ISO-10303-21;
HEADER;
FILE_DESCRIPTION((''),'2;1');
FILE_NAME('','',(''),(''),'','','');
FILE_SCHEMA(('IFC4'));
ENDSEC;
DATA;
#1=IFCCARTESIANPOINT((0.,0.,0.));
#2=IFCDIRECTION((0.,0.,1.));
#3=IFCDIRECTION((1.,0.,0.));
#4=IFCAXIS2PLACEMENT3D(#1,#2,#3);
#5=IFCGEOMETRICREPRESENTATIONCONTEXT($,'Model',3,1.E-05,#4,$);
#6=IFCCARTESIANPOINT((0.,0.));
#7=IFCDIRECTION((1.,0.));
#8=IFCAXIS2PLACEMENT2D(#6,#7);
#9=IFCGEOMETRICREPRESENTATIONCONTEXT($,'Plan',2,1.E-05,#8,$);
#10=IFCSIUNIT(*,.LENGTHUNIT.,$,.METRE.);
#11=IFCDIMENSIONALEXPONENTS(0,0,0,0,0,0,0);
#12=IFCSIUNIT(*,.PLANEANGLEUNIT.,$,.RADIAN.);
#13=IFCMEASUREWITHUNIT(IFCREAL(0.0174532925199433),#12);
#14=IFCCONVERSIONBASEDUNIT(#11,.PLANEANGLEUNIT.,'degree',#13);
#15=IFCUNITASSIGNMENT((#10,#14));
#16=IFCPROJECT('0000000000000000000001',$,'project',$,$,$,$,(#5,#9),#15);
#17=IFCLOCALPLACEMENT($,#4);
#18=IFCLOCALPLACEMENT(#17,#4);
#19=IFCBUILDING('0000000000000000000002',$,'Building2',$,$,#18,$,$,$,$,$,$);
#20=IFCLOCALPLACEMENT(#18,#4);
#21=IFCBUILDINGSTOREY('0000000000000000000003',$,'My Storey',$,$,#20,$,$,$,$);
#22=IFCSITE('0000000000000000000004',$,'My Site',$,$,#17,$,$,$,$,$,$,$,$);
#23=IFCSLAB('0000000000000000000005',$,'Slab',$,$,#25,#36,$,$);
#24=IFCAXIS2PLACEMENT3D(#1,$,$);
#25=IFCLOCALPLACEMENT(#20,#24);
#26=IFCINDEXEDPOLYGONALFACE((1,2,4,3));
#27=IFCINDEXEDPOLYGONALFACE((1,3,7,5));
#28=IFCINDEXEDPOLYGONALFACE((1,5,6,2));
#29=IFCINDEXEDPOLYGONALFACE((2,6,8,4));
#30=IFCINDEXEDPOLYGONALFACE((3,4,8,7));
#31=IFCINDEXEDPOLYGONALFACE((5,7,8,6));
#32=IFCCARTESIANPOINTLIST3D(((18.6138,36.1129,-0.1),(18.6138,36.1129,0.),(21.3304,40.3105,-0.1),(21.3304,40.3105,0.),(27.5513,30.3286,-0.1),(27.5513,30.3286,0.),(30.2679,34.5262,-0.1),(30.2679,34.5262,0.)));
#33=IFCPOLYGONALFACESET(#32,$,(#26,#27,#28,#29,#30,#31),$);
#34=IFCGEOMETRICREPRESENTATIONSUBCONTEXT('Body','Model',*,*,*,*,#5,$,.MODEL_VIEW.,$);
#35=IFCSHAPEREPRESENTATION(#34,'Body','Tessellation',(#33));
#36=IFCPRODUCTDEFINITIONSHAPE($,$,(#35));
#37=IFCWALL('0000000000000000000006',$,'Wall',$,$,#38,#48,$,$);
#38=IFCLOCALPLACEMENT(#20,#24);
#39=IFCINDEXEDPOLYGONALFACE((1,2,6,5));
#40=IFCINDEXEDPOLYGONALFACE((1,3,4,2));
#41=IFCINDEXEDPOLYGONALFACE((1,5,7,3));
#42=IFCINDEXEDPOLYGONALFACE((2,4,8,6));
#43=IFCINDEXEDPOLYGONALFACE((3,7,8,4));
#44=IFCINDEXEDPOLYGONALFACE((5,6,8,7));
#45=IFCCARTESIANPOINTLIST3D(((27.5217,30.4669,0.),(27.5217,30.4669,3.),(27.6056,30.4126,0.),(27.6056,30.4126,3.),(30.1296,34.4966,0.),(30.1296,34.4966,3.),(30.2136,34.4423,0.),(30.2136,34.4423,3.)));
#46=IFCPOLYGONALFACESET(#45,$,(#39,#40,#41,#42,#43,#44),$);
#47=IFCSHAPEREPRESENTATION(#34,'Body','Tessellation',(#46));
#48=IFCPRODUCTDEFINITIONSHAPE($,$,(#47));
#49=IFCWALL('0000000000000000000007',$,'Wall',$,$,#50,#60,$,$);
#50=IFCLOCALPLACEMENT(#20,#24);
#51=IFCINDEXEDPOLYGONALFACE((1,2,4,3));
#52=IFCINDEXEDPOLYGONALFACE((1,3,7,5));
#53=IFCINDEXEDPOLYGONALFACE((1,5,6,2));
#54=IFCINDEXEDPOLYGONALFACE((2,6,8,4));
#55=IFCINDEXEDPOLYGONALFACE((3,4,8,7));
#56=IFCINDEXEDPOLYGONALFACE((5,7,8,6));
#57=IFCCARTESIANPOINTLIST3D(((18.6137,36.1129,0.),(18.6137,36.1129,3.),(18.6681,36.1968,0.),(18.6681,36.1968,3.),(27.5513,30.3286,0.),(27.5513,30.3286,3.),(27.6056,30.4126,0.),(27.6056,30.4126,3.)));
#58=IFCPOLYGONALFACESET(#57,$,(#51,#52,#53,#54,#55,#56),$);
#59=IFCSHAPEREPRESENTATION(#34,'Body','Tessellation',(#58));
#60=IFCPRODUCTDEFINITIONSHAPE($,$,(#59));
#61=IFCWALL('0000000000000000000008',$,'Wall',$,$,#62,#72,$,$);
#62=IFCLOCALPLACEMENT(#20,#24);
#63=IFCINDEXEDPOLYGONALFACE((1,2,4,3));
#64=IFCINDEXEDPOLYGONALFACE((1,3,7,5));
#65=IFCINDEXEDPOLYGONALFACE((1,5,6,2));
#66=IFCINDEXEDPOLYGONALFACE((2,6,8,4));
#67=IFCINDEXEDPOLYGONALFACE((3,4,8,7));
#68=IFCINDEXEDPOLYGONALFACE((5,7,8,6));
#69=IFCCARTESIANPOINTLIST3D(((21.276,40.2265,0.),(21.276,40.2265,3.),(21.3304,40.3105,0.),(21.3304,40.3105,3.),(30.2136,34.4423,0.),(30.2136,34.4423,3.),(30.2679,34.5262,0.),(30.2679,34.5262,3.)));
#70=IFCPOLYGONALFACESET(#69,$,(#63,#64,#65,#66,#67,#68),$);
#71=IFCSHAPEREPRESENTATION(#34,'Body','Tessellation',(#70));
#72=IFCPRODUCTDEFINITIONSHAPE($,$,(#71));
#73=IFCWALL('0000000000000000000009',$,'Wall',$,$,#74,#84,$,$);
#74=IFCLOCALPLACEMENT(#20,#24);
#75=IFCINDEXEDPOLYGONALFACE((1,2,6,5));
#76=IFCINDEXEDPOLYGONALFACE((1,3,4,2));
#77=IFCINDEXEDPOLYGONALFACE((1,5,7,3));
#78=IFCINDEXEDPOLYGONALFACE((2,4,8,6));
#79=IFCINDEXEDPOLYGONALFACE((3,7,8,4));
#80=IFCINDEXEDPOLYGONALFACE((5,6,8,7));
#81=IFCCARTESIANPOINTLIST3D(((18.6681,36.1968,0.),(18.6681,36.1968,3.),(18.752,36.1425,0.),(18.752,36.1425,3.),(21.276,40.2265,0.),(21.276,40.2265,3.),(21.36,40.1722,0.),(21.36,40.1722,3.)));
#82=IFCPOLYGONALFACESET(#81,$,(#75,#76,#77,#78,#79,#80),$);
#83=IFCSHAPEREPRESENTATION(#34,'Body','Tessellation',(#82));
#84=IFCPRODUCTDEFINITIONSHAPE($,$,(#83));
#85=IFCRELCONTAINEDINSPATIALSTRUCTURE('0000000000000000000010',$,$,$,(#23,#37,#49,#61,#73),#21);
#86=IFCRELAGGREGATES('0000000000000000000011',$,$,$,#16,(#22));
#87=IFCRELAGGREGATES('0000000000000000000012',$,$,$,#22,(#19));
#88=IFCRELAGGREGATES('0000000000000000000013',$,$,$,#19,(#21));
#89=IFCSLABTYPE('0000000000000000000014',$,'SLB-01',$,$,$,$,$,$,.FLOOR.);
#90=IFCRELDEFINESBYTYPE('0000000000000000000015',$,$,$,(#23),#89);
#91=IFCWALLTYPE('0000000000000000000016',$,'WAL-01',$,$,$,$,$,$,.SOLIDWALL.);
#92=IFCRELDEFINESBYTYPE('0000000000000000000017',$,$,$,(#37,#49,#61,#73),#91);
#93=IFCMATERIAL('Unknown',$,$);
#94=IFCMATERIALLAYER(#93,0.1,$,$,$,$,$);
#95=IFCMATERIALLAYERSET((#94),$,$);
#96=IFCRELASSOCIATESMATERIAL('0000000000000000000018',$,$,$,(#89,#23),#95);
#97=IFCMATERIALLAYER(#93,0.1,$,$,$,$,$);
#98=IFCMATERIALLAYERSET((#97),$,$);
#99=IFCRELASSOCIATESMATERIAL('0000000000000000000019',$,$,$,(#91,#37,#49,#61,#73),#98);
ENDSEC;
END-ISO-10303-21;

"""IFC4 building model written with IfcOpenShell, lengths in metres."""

from ifc_helpers import new_model, entity, si_unit, converted_unit, frame, origin_with_axes, origin_2d_with_axis, place, context, subcontext, project, spatial, line, indexed_curve, outline, extrude, material, layer, layer_set, layer_usage, type_object, element, save


model = new_model("IFC4")

# Units and contexts
model_context = context("Model", 3, precision=1e-05, world=origin_with_axes())
plan_context = context("Plan", 2, precision=1e-05, world=origin_2d_with_axis())
body_context = subcontext(model_context, "Body", "Model", "MODEL_VIEW")
ifc_project = project(units=[si_unit("LENGTHUNIT", "METRE"), converted_unit("PLANEANGLEUNIT", "degree", entity("IfcReal", 0.0174532925199433), si_unit("PLANEANGLEUNIT", "RADIAN"), dimensions=[0, 0, 0, 0, 0, 0, 0])], contexts=[model_context, plan_context])

# Site, building, storey
site_placement = place(None, origin_with_axes())
site = spatial("IfcSite", under=ifc_project, at=site_placement, Name="My Site")
building_placement = place(site_placement, origin_with_axes())
building = spatial("IfcBuilding", under=site, at=building_placement, Name="Building2")
storey_placement = place(building_placement, origin_with_axes())
storey = spatial("IfcBuildingStorey", under=building, at=storey_placement, Name="My Storey")

# Slab
ifc_material = material(Name="Unknown")
ifc_layer_1 = layer(ifc_material, 0.1)
ifc_layer_set_1 = layer_set([ifc_layer_1])
ifc_layer_usage_1 = layer_usage(ifc_layer_set_1, "AXIS3", "POSITIVE", 0.0)
slab_type = type_object("IfcSlabType", Name="SLB-01", PredefinedType="FLOOR", material=ifc_layer_set_1)
slab_placement = place(storey_placement, frame((18.6138, 36.1129, -0.1), z_axis=(0.0, 0.0, 1.0), x_axis=(0.839523, -0.543324, 0.0)))
element("IfcSlab", 1, at=slab_placement, inside=storey, type_object=slab_type, material=ifc_layer_usage_1, Name="Slab", context=body_context, shape_type="SweptSolid", body=[
    extrude(outline(indexed_curve([(0.0, 0.0), (10.646, 0.0), (10.646, 5.0), (0.0, 5.0)], segments=[line(3, 2), line(2, 1), line(1, 4), line(4, 3)], self_intersect=False)), None, (0.0, 0.0, 1.0), 0.1),
])

# Walls
ifc_layer_2 = layer(ifc_material, 0.1)
ifc_layer_set_2 = layer_set([ifc_layer_2])
ifc_layer_usage_2 = layer_usage(ifc_layer_set_2, "AXIS2", "POSITIVE", 0.0)
wall_type = type_object("IfcWallType", Name="WAL-01", PredefinedType="SOLIDWALL", material=ifc_layer_set_2)
wall_1_placement = place(storey_placement, frame((27.6056, 30.4126, 0.0), z_axis=(0.0, 0.0, 1.0), x_axis=(0.543324, 0.839523, 0.0)))
element("IfcWall", 2, at=wall_1_placement, inside=storey, type_object=wall_type, material=ifc_layer_usage_2, Name="Wall", context=body_context, shape_type="SweptSolid", body=[
    extrude(outline(indexed_curve([(0.0, 0.0), (0.0, 0.1), (4.8, 0.1), (4.8, 0.0), (0.0, 0.0)], self_intersect=False)), origin_with_axes(), (0.0, 0.0, 1.0), 3.0),
])
ifc_layer_usage_3 = layer_usage(ifc_layer_set_2, "AXIS2", "POSITIVE", 0.0)
wall_2_placement = place(storey_placement, frame((27.6056, 30.4126, 0.0), z_axis=(0.0, 0.0, 1.0), x_axis=(-0.839523, 0.543324, 0.0)))
element("IfcWall", 3, at=wall_2_placement, inside=storey, type_object=wall_type, material=ifc_layer_usage_3, Name="Wall", context=body_context, shape_type="SweptSolid", body=[
    extrude(outline(indexed_curve([(0.0, 0.0), (0.0, 0.1), (10.646, 0.1), (10.646, 0.0), (0.0, 0.0)], self_intersect=False)), origin_with_axes(), (0.0, 0.0, 1.0), 3.0),
])
ifc_layer_usage_4 = layer_usage(ifc_layer_set_2, "AXIS2", "POSITIVE", 0.0)
wall_3_placement = place(storey_placement, frame((30.2679, 34.5262, 0.0), z_axis=(0.0, 0.0, 1.0), x_axis=(-0.839523, 0.543324, 0.0)))
element("IfcWall", 4, at=wall_3_placement, inside=storey, type_object=wall_type, material=ifc_layer_usage_4, Name="Wall", context=body_context, shape_type="SweptSolid", body=[
    extrude(outline(indexed_curve([(0.0, 0.0), (0.0, 0.1), (10.646, 0.1), (10.646, 0.0), (0.0, 0.0)], self_intersect=False)), origin_with_axes(), (0.0, 0.0, 1.0), 3.0),
])
ifc_layer_usage_5 = layer_usage(ifc_layer_set_2, "AXIS2", "POSITIVE", 0.0)
wall_4_placement = place(storey_placement, frame((18.752, 36.1425, 0.0), z_axis=(0.0, 0.0, 1.0), x_axis=(0.543324, 0.839523, 0.0)))
element("IfcWall", 5, at=wall_4_placement, inside=storey, type_object=wall_type, material=ifc_layer_usage_5, Name="Wall", context=body_context, shape_type="SweptSolid", body=[
    extrude(outline(indexed_curve([(0.0, 0.0), (0.0, 0.1), (4.8, 0.1), (4.8, 0.0), (0.0, 0.0)], self_intersect=False)), origin_with_axes(), (0.0, 0.0, 1.0), 3.0),
])

save(model, "model.ifc")
